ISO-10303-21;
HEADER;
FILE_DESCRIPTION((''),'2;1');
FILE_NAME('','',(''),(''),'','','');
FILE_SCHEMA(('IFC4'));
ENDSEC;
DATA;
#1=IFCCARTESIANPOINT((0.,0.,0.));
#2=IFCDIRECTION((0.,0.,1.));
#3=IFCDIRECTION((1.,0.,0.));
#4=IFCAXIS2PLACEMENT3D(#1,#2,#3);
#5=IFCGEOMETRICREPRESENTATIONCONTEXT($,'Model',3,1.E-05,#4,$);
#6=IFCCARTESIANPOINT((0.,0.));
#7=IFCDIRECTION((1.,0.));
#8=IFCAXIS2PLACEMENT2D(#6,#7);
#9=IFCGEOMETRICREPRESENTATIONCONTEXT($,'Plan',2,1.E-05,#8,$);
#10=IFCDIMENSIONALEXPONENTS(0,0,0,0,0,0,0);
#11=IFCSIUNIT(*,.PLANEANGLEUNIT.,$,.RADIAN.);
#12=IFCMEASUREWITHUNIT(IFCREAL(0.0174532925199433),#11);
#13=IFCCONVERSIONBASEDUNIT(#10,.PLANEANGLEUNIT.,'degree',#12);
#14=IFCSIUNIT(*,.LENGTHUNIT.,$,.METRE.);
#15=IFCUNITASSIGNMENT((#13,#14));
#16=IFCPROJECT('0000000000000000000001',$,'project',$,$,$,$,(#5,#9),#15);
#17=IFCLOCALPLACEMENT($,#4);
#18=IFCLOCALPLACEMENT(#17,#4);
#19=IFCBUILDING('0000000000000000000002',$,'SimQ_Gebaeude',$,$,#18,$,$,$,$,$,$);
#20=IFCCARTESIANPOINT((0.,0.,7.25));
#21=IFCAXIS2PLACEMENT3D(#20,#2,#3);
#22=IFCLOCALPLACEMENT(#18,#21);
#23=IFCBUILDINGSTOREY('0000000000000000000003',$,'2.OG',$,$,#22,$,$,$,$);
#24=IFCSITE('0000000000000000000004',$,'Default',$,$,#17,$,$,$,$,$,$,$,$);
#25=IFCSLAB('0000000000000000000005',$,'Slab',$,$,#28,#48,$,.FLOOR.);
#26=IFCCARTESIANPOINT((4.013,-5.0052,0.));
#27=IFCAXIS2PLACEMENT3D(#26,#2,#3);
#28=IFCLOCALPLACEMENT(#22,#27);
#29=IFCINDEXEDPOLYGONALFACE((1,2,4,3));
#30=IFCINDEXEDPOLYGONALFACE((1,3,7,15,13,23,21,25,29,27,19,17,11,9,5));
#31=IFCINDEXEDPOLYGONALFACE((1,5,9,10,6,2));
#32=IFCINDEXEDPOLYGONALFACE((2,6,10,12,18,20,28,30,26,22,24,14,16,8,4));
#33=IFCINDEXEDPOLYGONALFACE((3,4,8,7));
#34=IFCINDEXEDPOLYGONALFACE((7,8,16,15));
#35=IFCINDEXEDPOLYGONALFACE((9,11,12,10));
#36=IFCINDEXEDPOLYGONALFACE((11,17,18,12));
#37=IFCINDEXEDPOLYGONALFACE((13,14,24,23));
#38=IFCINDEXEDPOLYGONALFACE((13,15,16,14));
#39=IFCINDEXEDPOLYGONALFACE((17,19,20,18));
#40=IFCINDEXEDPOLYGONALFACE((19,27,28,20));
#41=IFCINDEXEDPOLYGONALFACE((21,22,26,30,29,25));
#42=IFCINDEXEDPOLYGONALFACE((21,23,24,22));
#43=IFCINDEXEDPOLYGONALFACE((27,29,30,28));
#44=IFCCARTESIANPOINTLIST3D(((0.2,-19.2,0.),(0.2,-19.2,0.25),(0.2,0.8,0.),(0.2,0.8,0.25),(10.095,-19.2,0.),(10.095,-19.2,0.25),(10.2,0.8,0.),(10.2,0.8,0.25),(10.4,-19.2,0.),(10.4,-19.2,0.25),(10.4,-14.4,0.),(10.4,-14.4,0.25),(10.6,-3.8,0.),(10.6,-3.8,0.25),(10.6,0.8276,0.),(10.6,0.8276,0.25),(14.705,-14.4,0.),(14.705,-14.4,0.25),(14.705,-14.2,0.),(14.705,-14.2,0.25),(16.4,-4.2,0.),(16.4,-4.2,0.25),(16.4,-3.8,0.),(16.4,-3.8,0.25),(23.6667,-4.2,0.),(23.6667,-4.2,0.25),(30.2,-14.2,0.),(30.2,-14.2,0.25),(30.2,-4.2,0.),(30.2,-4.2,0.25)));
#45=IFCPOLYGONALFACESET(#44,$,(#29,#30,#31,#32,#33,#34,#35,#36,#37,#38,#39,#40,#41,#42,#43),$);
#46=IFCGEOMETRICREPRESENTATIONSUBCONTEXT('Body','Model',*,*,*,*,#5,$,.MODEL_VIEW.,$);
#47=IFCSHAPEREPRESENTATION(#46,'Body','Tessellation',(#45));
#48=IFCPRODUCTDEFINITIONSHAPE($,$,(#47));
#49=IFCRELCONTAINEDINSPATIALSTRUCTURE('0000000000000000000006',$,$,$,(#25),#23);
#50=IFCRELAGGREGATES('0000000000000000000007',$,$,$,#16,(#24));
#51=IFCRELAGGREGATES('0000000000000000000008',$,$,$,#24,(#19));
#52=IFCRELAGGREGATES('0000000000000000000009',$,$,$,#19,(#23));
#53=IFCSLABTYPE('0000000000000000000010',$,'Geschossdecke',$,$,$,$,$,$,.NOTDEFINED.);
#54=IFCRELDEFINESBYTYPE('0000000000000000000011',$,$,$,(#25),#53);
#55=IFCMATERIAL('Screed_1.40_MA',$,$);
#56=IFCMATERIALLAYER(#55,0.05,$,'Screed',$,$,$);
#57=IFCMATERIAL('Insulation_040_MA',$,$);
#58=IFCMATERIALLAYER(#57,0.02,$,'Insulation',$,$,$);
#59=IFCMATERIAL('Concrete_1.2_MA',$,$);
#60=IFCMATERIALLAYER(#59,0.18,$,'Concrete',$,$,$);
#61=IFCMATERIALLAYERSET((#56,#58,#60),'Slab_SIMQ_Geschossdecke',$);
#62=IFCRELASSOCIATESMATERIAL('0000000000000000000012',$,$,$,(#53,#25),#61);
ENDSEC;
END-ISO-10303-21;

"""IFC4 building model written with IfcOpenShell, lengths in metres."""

from ifc_helpers import new_model, entity, si_unit, converted_unit, frame, origin_with_axes, origin_2d_with_axis, place, context, subcontext, project, spatial, line, indexed_curve, outline, extrude, material, layer, layer_set, layer_usage, type_object, element, save


model = new_model("IFC4")

# Units and contexts
model_context = context("Model", 3, precision=1e-05, world=origin_with_axes())
plan_context = context("Plan", 2, precision=1e-05, world=origin_2d_with_axis())
body_context = subcontext(model_context, "Body", "Model", "MODEL_VIEW")
ifc_project = project(units=[converted_unit("PLANEANGLEUNIT", "degree", entity("IfcReal", 0.0174532925199433), si_unit("PLANEANGLEUNIT", "RADIAN"), dimensions=[0, 0, 0, 0, 0, 0, 0]), si_unit("LENGTHUNIT", "METRE")], contexts=[model_context, plan_context])

# Site, building, storey
site_placement = place(None, origin_with_axes())
site = spatial("IfcSite", under=ifc_project, at=site_placement, Name="Default")
building_placement = place(site_placement, origin_with_axes())
building = spatial("IfcBuilding", under=site, at=building_placement, Name="SimQ_Gebaeude")
storey_placement = place(building_placement, frame((0.0, 0.0, 7.25), z_axis=(0.0, 0.0, 1.0), x_axis=(1.0, 0.0, 0.0)))
storey = spatial("IfcBuildingStorey", under=building, at=storey_placement, Name="2.OG")

# Slab
ifc_material_1 = material(Name="Screed_1.40_MA")
ifc_layer_1 = layer(ifc_material_1, 0.05, Name="Screed")
ifc_material_2 = material(Name="Insulation_040_MA")
ifc_layer_2 = layer(ifc_material_2, 0.02, Name="Insulation")
ifc_material_3 = material(Name="Concrete_1.2_MA")
ifc_layer_3 = layer(ifc_material_3, 0.18, Name="Concrete")
ifc_layer_set_1 = layer_set([ifc_layer_1, ifc_layer_2, ifc_layer_3], Name="Slab_SIMQ_Geschossdecke")
ifc_layer_usage_1 = layer_usage(ifc_layer_set_1, "AXIS3", "POSITIVE", 0.0)
slab_type = type_object("IfcSlabType", Name="Geschossdecke", PredefinedType="NOTDEFINED", material=ifc_layer_set_1)
slab_placement = place(storey_placement, frame((4.013, -5.0052, 0.0), z_axis=(0.0, 0.0, 1.0), x_axis=(1.0, 0.0, 0.0)))
element("IfcSlab", 1, at=slab_placement, inside=storey, type_object=slab_type, material=ifc_layer_usage_1, Name="Slab", PredefinedType="FLOOR", context=body_context, shape_type="SweptSolid", body=[
    extrude(outline(indexed_curve([(10.4, -19.2), (10.4, -14.4), (30.2, -14.2), (30.2, -4.2), (10.6, -3.8), (10.6, 0.8276), (10.2, 0.8), (0.2, 0.8), (0.2, -19.2), (10.095, -19.2), (23.6667, -4.2), (16.4, -4.2), (16.4, -3.8), (14.705, -14.4), (14.705, -14.2)], segments=[line(15, 14), line(14, 2), line(2, 1), line(1, 10), line(10, 9), line(9, 8), line(8, 7), line(7, 6), line(6, 5), line(5, 13), line(13, 12), line(12, 11), line(11, 4), line(4, 3), line(3, 15)], self_intersect=False)), None, (0.0, 0.0, 1.0), 0.25),
])

save(model, "model.ifc")
